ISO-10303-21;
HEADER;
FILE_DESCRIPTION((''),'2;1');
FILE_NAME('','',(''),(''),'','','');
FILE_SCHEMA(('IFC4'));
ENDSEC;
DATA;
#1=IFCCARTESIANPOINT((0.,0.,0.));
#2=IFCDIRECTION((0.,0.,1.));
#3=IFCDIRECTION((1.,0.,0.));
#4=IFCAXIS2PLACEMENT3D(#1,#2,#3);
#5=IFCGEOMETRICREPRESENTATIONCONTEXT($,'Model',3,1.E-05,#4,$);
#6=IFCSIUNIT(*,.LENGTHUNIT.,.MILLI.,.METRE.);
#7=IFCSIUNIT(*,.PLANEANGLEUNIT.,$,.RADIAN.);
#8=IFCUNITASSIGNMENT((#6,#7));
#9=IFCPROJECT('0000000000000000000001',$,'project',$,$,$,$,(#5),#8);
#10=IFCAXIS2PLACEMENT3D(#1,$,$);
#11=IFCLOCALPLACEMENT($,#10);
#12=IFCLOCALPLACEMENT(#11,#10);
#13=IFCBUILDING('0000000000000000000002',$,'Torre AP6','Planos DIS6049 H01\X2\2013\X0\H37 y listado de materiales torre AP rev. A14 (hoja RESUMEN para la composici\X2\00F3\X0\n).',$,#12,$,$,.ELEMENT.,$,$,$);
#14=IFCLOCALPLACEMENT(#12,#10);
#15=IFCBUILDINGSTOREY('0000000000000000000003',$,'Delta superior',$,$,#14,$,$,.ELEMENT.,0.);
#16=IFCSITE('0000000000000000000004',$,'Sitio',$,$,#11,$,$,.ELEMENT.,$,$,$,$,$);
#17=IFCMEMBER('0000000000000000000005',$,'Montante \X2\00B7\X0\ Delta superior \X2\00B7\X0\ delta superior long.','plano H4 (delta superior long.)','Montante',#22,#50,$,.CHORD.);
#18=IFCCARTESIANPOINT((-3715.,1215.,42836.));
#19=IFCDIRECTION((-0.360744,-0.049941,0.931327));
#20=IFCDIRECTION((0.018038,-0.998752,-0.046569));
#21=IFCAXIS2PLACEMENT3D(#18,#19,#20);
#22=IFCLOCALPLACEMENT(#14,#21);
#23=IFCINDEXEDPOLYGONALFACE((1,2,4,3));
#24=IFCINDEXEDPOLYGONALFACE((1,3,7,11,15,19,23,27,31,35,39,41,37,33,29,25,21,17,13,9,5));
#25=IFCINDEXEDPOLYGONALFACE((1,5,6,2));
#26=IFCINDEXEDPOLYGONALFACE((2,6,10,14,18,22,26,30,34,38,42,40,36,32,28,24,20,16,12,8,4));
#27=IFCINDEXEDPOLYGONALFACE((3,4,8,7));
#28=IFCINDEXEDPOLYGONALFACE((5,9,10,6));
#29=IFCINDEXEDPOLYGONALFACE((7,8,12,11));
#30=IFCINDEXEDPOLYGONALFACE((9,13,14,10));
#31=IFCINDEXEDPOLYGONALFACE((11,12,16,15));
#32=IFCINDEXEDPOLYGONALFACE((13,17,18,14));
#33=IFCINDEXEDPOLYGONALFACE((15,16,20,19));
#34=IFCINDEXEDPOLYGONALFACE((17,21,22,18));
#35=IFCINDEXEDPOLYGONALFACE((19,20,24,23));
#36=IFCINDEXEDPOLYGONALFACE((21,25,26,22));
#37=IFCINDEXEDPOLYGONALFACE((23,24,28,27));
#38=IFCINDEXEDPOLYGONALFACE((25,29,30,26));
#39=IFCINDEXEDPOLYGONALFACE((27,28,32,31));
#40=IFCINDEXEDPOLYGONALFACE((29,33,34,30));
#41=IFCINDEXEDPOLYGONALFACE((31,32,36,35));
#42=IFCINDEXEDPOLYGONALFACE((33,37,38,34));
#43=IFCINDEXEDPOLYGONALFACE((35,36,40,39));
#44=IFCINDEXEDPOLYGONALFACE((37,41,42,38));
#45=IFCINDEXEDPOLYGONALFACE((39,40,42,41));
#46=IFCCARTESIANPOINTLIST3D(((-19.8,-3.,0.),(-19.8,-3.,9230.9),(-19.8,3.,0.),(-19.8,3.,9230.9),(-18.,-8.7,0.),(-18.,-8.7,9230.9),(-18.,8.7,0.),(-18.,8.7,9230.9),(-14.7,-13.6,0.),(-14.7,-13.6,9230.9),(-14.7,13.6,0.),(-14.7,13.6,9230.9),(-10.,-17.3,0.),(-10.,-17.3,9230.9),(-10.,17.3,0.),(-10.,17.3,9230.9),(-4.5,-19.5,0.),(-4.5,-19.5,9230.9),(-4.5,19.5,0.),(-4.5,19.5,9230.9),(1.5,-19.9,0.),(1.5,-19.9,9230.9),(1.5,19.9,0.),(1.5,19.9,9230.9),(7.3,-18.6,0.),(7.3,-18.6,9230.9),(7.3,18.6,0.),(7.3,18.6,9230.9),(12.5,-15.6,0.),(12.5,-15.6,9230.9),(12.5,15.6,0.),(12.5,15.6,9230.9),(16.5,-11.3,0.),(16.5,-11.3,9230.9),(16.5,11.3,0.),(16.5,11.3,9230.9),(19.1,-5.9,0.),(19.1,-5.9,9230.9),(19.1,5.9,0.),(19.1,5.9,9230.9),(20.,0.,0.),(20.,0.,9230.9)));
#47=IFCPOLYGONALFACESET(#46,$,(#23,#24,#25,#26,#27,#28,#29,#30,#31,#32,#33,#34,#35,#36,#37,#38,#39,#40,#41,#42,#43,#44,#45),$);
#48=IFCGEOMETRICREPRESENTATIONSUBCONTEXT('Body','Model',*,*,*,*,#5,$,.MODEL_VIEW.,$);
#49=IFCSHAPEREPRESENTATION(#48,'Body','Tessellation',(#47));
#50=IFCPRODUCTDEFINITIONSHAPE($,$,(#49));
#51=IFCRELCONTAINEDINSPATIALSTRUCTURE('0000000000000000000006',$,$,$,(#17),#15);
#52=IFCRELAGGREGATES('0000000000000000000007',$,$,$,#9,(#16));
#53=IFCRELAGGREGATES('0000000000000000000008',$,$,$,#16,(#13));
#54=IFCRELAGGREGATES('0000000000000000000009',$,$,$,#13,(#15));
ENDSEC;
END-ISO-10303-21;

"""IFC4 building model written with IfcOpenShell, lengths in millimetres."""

from ifc_helpers import new_model, si_unit, frame, origin, origin_with_axes, place, context, subcontext, project, spatial, circle, extrude, element, save


model = new_model("IFC4")

# Units and contexts
model_context = context("Model", 3, precision=1e-05, world=origin_with_axes())
body_context = subcontext(model_context, "Body", "Model", "MODEL_VIEW")
ifc_project = project(units=[si_unit("LENGTHUNIT", "METRE", prefix="MILLI"), si_unit("PLANEANGLEUNIT", "RADIAN")], contexts=[model_context])

# Site, building, storey
site_placement = place(None, origin())
site = spatial("IfcSite", under=ifc_project, at=site_placement, Name="Sitio", CompositionType="ELEMENT")
building_placement = place(site_placement, origin())
building = spatial("IfcBuilding", under=site, at=building_placement, Name="Torre AP6", Description="Planos DIS6049 H01–H37 y listado de materiales torre AP rev. A14 (hoja RESUMEN para la composición).", CompositionType="ELEMENT")
storey_placement = place(building_placement, origin())
storey = spatial("IfcBuildingStorey", under=building, at=storey_placement, Name="Delta superior", CompositionType="ELEMENT", Elevation=0.0)

# Member
for number, where, z_axis, x_axis, name in (
    (1, (-3715.0, 1215.0, 42836.0), (-0.360744, -0.049941, 0.931327), (0.018038, -0.998752, -0.046569), "Montante · Delta superior · delta superior long."),
):
    element("IfcMember", number, at=place(storey_placement, frame(where, z_axis=z_axis, x_axis=x_axis)), inside=storey, Name=name, Description="plano H4 (delta superior long.)", ObjectType="Montante", PredefinedType="CHORD", context=body_context, shape_type="SweptSolid", body=[
        extrude(circle(Radius=20.0), None, (0.0, 0.0, 1.0), 9230.9),
    ])

save(model, "model.ifc")
